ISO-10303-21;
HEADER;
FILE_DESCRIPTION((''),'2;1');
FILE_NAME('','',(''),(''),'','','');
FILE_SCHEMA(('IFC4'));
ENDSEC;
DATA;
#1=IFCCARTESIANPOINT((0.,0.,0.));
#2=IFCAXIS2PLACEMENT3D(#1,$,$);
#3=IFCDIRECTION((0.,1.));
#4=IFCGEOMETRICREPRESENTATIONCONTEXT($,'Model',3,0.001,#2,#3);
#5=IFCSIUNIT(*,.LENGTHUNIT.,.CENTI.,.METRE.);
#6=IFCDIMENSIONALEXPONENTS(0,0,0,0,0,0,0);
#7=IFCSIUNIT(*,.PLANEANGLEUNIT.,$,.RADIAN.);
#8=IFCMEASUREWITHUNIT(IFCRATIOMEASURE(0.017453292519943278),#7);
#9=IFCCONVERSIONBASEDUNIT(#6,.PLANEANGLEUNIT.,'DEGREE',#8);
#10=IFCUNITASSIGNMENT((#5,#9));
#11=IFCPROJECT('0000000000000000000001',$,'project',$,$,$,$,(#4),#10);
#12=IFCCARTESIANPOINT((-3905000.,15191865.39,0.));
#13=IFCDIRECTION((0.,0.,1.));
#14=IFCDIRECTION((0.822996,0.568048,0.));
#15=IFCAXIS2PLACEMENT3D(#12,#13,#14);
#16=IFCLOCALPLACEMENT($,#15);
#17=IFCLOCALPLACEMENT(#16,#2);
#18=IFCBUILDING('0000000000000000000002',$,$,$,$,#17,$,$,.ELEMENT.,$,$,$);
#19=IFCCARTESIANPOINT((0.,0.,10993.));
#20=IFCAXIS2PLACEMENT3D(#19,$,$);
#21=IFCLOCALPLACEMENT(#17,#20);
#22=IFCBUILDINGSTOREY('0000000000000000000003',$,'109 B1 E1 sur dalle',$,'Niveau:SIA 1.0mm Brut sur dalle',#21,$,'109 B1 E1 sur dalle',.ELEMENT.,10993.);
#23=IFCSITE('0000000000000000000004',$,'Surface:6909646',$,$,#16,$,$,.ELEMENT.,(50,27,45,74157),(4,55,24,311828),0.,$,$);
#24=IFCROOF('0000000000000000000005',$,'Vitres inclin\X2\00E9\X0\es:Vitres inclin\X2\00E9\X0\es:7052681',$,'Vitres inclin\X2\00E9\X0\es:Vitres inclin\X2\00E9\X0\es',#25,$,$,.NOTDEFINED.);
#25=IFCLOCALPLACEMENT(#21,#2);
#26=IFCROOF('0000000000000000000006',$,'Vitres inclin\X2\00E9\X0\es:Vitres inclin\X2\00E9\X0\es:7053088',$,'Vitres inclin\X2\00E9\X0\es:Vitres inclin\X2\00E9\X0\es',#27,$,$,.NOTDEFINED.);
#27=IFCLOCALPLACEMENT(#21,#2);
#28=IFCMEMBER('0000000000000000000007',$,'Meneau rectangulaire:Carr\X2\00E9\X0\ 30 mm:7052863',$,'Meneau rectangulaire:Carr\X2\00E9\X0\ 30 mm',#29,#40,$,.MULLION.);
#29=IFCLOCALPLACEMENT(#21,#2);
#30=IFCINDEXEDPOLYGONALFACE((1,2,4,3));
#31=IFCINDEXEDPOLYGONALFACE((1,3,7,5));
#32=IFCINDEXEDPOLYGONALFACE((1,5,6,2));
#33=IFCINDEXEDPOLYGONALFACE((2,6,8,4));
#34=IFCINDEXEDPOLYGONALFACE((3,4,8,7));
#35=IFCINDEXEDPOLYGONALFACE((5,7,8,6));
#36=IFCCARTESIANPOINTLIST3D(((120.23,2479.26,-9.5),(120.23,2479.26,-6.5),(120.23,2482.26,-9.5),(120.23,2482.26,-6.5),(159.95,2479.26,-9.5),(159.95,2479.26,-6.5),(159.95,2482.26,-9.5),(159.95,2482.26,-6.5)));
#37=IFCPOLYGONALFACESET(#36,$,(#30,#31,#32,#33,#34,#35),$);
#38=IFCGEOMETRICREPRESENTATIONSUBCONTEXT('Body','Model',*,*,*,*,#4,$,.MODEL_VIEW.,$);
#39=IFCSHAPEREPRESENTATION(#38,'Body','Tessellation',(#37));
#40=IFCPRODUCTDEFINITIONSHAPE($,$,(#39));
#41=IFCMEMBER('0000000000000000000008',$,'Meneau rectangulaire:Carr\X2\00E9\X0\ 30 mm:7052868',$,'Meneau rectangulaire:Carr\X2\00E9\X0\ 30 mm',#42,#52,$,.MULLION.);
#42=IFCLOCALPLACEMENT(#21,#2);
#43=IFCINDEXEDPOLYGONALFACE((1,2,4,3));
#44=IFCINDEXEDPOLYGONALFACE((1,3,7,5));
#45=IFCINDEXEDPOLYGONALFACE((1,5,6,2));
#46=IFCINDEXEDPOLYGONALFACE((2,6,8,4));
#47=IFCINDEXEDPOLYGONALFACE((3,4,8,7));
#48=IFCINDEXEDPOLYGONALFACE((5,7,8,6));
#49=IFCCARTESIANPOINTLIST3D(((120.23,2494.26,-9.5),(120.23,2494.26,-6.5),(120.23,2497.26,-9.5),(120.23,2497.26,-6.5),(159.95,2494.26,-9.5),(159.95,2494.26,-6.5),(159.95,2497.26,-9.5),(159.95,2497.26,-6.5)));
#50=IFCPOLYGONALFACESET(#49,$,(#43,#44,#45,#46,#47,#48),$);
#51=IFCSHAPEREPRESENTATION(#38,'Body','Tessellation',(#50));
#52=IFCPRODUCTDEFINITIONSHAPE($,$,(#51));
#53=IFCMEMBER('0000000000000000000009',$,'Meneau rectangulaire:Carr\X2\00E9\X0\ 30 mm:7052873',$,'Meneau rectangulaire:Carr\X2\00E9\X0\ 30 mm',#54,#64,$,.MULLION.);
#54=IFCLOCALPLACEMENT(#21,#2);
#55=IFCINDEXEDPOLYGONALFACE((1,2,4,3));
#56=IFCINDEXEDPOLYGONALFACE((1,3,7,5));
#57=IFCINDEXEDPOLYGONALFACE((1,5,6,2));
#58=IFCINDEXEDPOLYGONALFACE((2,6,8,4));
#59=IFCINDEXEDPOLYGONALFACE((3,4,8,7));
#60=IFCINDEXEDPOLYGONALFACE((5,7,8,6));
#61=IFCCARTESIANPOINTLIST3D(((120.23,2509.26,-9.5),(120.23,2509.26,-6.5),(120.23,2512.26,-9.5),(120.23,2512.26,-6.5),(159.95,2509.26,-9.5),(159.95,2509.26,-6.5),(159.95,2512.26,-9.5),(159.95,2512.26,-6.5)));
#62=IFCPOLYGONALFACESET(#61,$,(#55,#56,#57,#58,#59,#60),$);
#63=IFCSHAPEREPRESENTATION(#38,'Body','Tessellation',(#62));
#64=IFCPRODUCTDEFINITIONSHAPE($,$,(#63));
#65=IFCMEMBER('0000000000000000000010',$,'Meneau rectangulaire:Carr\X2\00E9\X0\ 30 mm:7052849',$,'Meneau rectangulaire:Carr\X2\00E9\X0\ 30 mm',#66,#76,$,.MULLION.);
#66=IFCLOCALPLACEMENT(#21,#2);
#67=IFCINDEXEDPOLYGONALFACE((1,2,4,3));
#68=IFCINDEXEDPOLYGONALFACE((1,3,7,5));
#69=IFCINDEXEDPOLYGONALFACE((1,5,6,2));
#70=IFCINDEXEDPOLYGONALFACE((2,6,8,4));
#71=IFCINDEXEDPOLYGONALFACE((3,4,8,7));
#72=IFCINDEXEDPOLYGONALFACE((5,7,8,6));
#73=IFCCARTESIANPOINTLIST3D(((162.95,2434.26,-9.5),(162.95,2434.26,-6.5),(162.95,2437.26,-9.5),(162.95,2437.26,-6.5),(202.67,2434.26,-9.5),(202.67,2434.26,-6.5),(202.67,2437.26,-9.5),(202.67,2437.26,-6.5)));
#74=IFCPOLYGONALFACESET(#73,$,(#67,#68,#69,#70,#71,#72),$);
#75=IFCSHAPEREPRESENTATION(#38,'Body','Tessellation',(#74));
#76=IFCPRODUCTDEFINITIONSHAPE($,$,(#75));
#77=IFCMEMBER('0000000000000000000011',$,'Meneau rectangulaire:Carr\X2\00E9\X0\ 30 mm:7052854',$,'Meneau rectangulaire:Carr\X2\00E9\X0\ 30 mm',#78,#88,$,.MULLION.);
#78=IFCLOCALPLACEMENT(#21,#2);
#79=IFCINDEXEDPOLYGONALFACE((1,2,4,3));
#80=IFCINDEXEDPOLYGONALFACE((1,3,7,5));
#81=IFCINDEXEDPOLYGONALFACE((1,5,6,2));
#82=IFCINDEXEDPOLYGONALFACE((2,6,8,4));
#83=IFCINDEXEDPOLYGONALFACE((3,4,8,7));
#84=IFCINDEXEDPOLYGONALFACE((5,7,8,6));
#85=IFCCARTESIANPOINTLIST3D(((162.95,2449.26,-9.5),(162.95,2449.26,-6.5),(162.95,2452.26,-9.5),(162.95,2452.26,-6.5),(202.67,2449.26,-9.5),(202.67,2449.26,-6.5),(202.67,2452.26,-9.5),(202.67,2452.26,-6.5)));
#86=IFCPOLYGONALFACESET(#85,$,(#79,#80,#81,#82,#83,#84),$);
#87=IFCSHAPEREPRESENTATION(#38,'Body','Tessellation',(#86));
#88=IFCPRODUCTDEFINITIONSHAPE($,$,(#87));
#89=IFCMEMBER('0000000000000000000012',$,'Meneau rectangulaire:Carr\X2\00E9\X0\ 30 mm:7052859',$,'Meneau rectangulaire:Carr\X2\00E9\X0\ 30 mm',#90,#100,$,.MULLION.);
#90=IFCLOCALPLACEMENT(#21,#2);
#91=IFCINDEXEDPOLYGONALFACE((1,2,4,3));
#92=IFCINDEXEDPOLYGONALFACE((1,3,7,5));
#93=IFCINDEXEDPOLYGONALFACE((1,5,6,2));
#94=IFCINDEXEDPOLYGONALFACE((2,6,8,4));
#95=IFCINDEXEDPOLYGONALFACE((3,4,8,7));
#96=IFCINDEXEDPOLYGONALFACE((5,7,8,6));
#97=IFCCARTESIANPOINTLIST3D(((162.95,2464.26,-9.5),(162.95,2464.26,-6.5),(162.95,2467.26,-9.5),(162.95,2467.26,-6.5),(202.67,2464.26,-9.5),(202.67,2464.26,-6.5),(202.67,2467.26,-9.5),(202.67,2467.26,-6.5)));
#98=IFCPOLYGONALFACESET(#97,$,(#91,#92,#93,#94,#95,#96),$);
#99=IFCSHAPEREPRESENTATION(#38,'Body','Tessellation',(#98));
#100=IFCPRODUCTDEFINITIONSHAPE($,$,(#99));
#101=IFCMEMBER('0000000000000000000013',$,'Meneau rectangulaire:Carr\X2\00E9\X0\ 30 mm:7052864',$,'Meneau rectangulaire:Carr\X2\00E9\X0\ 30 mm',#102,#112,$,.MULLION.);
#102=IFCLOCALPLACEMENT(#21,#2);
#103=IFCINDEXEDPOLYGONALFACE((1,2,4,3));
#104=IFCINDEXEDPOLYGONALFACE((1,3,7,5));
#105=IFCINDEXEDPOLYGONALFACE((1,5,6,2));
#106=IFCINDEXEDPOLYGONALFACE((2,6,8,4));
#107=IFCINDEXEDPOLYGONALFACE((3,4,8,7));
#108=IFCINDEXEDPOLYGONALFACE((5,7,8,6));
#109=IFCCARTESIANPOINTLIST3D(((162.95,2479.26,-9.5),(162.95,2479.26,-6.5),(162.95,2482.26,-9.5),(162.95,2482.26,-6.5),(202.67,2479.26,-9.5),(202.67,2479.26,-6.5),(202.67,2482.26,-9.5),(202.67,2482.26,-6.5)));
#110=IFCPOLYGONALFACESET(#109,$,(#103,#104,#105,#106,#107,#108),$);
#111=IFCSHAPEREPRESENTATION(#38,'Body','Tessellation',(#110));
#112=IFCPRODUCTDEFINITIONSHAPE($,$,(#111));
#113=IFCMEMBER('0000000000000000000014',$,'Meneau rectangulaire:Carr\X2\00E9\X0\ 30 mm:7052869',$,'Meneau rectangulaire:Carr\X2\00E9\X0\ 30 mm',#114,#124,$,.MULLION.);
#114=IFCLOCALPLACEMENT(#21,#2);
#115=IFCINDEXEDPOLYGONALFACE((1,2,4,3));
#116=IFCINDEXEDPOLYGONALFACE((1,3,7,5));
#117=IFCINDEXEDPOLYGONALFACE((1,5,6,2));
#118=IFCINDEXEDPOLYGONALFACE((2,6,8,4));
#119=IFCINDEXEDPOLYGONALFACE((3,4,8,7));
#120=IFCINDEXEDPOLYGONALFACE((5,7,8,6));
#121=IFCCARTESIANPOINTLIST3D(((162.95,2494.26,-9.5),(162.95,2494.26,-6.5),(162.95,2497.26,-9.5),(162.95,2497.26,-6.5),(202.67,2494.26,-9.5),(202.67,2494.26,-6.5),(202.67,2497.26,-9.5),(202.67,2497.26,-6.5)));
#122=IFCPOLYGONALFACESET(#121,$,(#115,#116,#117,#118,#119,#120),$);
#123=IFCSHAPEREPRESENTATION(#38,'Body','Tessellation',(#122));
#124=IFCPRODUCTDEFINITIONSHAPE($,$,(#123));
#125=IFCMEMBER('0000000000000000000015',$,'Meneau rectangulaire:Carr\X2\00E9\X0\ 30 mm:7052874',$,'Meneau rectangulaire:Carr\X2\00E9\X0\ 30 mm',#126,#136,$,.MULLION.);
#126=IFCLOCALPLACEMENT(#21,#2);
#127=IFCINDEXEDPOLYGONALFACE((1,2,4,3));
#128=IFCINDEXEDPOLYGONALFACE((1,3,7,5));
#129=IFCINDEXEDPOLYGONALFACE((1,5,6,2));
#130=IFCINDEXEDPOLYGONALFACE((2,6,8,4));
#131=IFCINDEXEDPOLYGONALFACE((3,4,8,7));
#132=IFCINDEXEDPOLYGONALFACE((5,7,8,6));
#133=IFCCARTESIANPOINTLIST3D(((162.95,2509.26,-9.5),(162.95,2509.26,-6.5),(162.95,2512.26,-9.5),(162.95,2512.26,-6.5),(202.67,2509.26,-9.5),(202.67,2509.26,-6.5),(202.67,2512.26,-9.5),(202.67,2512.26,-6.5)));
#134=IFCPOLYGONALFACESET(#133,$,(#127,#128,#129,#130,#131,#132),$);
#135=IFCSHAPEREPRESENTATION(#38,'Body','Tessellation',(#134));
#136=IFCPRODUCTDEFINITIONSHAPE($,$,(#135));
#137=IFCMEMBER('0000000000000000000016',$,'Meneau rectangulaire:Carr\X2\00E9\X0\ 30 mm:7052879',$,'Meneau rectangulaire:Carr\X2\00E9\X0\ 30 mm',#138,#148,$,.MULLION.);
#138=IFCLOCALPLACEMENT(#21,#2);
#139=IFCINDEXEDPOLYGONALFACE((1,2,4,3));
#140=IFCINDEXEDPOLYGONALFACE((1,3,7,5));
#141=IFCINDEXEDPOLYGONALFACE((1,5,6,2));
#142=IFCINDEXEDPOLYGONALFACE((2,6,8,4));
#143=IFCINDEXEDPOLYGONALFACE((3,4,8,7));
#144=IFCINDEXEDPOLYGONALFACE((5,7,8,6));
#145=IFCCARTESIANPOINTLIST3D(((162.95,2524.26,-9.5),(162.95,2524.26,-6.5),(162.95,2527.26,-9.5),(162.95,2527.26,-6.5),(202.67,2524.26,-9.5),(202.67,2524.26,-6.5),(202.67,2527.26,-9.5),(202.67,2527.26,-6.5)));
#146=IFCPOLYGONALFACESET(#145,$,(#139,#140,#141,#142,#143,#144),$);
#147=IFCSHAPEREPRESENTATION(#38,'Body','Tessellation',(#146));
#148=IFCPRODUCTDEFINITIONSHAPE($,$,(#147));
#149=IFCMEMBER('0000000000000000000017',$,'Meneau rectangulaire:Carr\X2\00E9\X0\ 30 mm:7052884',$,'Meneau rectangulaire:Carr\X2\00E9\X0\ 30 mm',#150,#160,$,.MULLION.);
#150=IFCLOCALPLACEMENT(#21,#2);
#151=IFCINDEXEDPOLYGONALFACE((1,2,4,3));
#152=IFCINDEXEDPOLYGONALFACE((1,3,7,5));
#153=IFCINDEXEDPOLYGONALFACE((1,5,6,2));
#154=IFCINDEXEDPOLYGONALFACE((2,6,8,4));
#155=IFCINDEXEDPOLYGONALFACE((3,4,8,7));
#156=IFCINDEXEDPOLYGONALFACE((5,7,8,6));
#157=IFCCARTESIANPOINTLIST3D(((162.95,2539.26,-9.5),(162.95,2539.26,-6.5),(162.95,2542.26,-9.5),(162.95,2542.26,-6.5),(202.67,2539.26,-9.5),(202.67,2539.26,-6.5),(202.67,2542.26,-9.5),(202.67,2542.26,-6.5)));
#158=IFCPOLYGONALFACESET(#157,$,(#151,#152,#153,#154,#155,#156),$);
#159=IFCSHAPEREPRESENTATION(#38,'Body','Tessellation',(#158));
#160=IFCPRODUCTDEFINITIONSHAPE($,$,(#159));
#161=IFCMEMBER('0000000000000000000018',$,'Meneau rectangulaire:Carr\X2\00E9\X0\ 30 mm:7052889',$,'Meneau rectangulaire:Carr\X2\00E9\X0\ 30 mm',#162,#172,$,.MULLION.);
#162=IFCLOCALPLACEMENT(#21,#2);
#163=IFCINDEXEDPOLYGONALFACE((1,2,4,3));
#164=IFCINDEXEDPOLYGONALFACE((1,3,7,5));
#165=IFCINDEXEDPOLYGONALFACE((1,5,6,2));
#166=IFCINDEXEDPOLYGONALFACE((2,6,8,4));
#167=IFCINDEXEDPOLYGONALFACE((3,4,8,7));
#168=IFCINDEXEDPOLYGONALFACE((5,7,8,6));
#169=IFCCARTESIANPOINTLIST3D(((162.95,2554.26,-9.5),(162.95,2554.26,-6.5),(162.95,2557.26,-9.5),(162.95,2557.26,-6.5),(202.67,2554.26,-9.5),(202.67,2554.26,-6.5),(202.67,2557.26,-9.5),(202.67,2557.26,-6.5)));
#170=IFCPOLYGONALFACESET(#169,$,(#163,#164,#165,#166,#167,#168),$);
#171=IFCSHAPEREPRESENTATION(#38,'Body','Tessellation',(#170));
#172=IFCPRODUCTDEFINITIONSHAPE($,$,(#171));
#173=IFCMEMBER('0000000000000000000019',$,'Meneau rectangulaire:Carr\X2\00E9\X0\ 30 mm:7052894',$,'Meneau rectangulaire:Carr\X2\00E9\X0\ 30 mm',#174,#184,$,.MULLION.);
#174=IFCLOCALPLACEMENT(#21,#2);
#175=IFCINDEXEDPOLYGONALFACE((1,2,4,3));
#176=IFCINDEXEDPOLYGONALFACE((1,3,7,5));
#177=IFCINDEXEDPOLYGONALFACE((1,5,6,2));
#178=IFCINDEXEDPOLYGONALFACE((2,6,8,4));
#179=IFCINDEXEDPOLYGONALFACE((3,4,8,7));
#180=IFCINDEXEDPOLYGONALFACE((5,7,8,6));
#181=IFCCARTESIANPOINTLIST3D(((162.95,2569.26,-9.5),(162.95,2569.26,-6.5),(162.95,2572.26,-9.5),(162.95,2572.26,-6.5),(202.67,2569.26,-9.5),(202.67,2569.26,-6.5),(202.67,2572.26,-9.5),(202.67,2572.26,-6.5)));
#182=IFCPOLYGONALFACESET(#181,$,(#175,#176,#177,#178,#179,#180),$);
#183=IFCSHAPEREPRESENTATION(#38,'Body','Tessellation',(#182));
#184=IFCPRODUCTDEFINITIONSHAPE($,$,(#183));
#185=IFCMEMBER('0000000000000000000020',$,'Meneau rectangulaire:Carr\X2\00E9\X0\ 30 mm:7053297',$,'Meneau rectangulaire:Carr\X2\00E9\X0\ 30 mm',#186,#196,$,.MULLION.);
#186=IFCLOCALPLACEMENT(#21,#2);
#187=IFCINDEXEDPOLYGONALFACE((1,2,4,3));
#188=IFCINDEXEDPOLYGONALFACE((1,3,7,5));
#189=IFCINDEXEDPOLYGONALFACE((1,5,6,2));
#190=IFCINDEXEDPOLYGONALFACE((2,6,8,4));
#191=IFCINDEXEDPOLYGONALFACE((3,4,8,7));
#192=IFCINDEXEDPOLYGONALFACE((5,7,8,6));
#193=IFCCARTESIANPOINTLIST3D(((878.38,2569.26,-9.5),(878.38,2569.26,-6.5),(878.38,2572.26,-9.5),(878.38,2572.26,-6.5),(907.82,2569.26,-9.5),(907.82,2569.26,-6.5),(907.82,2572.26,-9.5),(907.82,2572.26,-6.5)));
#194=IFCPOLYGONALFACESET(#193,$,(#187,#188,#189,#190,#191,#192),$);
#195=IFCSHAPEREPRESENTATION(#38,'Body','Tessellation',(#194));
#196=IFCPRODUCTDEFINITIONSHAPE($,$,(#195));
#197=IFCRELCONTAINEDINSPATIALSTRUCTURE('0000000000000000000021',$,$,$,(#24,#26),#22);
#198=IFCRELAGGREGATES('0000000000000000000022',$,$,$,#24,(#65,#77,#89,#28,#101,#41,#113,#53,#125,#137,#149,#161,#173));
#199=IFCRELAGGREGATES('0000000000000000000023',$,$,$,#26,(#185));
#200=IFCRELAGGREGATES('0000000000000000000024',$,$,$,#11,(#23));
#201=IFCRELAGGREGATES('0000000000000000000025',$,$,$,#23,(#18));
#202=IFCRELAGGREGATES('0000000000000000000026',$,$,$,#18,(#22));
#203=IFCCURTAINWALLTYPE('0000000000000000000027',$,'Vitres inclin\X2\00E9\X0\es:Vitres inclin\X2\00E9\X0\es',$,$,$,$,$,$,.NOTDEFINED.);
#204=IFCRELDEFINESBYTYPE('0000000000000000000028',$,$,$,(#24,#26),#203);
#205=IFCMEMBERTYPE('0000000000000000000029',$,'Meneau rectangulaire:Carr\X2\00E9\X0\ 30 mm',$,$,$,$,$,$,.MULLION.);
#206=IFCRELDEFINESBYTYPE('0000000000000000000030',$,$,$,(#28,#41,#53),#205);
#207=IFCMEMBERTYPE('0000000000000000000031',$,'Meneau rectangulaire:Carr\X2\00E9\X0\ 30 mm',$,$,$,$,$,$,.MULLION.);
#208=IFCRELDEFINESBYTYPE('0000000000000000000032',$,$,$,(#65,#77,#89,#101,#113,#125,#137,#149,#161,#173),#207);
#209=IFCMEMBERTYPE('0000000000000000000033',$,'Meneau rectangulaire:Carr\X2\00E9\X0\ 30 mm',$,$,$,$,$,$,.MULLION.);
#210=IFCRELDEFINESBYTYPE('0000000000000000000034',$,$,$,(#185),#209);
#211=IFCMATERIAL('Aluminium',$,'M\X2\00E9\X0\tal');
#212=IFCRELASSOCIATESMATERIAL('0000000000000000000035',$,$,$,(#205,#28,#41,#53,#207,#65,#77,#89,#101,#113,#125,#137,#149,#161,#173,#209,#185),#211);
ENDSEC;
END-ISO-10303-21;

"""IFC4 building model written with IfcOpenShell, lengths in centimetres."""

from ifc_helpers import new_model, entity, si_unit, converted_unit, direction, frame, origin, place, context, subcontext, project, spatial, indexed_curve, outline, extrude, source, transform, mapped, material, type_object, type_shapes, element, aggregate, save


model = new_model("IFC4")

# Units and contexts
model_context = context("Model", 3, precision=0.001, world=origin(), true_north=direction((0.0, 1.0)))
body_context = subcontext(model_context, "Body", "Model", "MODEL_VIEW")
ifc_project = project(units=[si_unit("LENGTHUNIT", "METRE", prefix="CENTI"), converted_unit("PLANEANGLEUNIT", "DEGREE", entity("IfcRatioMeasure", 0.017453292519943278), si_unit("PLANEANGLEUNIT", "RADIAN"), dimensions=[0, 0, 0, 0, 0, 0, 0])], contexts=[model_context])

# Site, building, storey
site_placement = place(None, frame((-3905000.0, 15191865.39, 0.0), z_axis=(0.0, 0.0, 1.0), x_axis=(0.822996, 0.568048, 0.0)))
site = spatial("IfcSite", under=ifc_project, at=site_placement, Name="Surface:6909646", CompositionType="ELEMENT", RefLatitude=(50, 27, 45, 74157), RefLongitude=(4, 55, 24, 311828), RefElevation=0.0)
building_placement = place(site_placement, origin())
building = spatial("IfcBuilding", under=site, at=building_placement, CompositionType="ELEMENT")
storey_placement = place(building_placement, frame((0.0, 0.0, 10993.0)))
storey = spatial("IfcBuildingStorey", under=building, at=storey_placement, Name="109 B1 E1 sur dalle", ObjectType="Niveau:SIA 1.0mm Brut sur dalle", LongName="109 B1 E1 sur dalle", CompositionType="ELEMENT", Elevation=10993.0)

# Roofs
curtain_wall_type = type_object("IfcCurtainWallType", Name="Vitres inclinées:Vitres inclinées", PredefinedType="NOTDEFINED")
roof_1_placement = place(storey_placement, frame((0.0, 0.0, -10993.0)))
roof_1 = element("IfcRoof", 1, at=roof_1_placement, inside=storey, type_object=curtain_wall_type, Name="Vitres inclinées:Vitres inclinées:7052681", ObjectType="Vitres inclinées:Vitres inclinées", PredefinedType="NOTDEFINED")
ifc_material = material(Name="Aluminium", Category="Métal")
roof_2_placement = place(storey_placement, frame((0.0, 0.0, -10993.0)))
roof_2 = element("IfcRoof", 2, at=roof_2_placement, inside=storey, type_object=curtain_wall_type, Name="Vitres inclinées:Vitres inclinées:7053088", ObjectType="Vitres inclinées:Vitres inclinées", PredefinedType="NOTDEFINED")

# Members
member_type_1 = type_object("IfcMemberType", Name="Meneau rectangulaire:Carré 30 mm", PredefinedType="MULLION", material=ifc_material)
shared_shape_1 = source(origin(), body_context, "Body", "SweptSolid", [
    extrude(outline(indexed_curve([(-1.5, -1.5), (1.5, -1.5), (1.5, 1.5), (-1.5, 1.5), (-1.5, -1.5)], self_intersect=False)), frame((0.0, 0.0, -39.72), z_axis=(0.0, 0.0, 1.0), x_axis=(0.0, -1.0, 0.0)), (0.0, 0.0, 1.0), 39.72),
])
type_shapes(member_type_1, [shared_shape_1])
member_1_placement = place(roof_1_placement, frame((120.23, 2480.76, 10985.0), z_axis=(-1.0, 0.0, 0.0), x_axis=(0.0, 1.0, 0.0)))
member_1 = element("IfcMember", 3, at=member_1_placement, type_object=member_type_1, material=ifc_material, Name="Meneau rectangulaire:Carré 30 mm:7052863", ObjectType="Meneau rectangulaire:Carré 30 mm", PredefinedType="MULLION", context=body_context, shape_type="MappedRepresentation", body=[
    mapped(shared_shape_1, transform((0.0, 0.0, 0.0), scale=1.0)),
])
member_2_placement = place(roof_1_placement, frame((120.23, 2495.76, 10985.0), z_axis=(-1.0, 0.0, 0.0), x_axis=(0.0, 1.0, 0.0)))
member_2 = element("IfcMember", 4, at=member_2_placement, type_object=member_type_1, material=ifc_material, Name="Meneau rectangulaire:Carré 30 mm:7052868", ObjectType="Meneau rectangulaire:Carré 30 mm", PredefinedType="MULLION", context=body_context, shape_type="MappedRepresentation", body=[
    mapped(shared_shape_1, transform((0.0, 0.0, 0.0), scale=1.0)),
])
member_3_placement = place(roof_1_placement, frame((120.23, 2510.76, 10985.0), z_axis=(-1.0, 0.0, 0.0), x_axis=(0.0, 1.0, 0.0)))
member_3 = element("IfcMember", 5, at=member_3_placement, type_object=member_type_1, material=ifc_material, Name="Meneau rectangulaire:Carré 30 mm:7052873", ObjectType="Meneau rectangulaire:Carré 30 mm", PredefinedType="MULLION", context=body_context, shape_type="MappedRepresentation", body=[
    mapped(shared_shape_1, transform((0.0, 0.0, 0.0), scale=1.0)),
])
member_type_2 = type_object("IfcMemberType", Name="Meneau rectangulaire:Carré 30 mm", PredefinedType="MULLION", material=ifc_material)
shared_shape_2 = source(origin(), body_context, "Body", "SweptSolid", [
    extrude(outline(indexed_curve([(-1.5, -1.5), (1.5, -1.5), (1.5, 1.5), (-1.5, 1.5), (-1.5, -1.5)], self_intersect=False)), frame((0.0, 0.0, -39.72), z_axis=(0.0, 0.0, 1.0), x_axis=(0.0, -1.0, 0.0)), (0.0, 0.0, 1.0), 39.72),
])
type_shapes(member_type_2, [shared_shape_2])
member_4_placement = place(roof_1_placement, frame((162.95, 2435.76, 10985.0), z_axis=(-1.0, 0.0, 0.0), x_axis=(0.0, 1.0, 0.0)))
member_4 = element("IfcMember", 6, at=member_4_placement, type_object=member_type_2, material=ifc_material, Name="Meneau rectangulaire:Carré 30 mm:7052849", ObjectType="Meneau rectangulaire:Carré 30 mm", PredefinedType="MULLION", context=body_context, shape_type="MappedRepresentation", body=[
    mapped(shared_shape_2, transform((0.0, 0.0, 0.0), scale=1.0)),
])
member_5_placement = place(roof_1_placement, frame((162.95, 2450.76, 10985.0), z_axis=(-1.0, 0.0, 0.0), x_axis=(0.0, 1.0, 0.0)))
member_5 = element("IfcMember", 7, at=member_5_placement, type_object=member_type_2, material=ifc_material, Name="Meneau rectangulaire:Carré 30 mm:7052854", ObjectType="Meneau rectangulaire:Carré 30 mm", PredefinedType="MULLION", context=body_context, shape_type="MappedRepresentation", body=[
    mapped(shared_shape_2, transform((0.0, 0.0, 0.0), scale=1.0)),
])
member_6_placement = place(roof_1_placement, frame((162.95, 2465.76, 10985.0), z_axis=(-1.0, 0.0, 0.0), x_axis=(0.0, 1.0, 0.0)))
member_6 = element("IfcMember", 8, at=member_6_placement, type_object=member_type_2, material=ifc_material, Name="Meneau rectangulaire:Carré 30 mm:7052859", ObjectType="Meneau rectangulaire:Carré 30 mm", PredefinedType="MULLION", context=body_context, shape_type="MappedRepresentation", body=[
    mapped(shared_shape_2, transform((0.0, 0.0, 0.0), scale=1.0)),
])
member_7_placement = place(roof_1_placement, frame((162.95, 2480.76, 10985.0), z_axis=(-1.0, 0.0, 0.0), x_axis=(0.0, 1.0, 0.0)))
member_7 = element("IfcMember", 9, at=member_7_placement, type_object=member_type_2, material=ifc_material, Name="Meneau rectangulaire:Carré 30 mm:7052864", ObjectType="Meneau rectangulaire:Carré 30 mm", PredefinedType="MULLION", context=body_context, shape_type="MappedRepresentation", body=[
    mapped(shared_shape_2, transform((0.0, 0.0, 0.0), scale=1.0)),
])
member_8_placement = place(roof_1_placement, frame((162.95, 2495.76, 10985.0), z_axis=(-1.0, 0.0, 0.0), x_axis=(0.0, 1.0, 0.0)))
member_8 = element("IfcMember", 10, at=member_8_placement, type_object=member_type_2, material=ifc_material, Name="Meneau rectangulaire:Carré 30 mm:7052869", ObjectType="Meneau rectangulaire:Carré 30 mm", PredefinedType="MULLION", context=body_context, shape_type="MappedRepresentation", body=[
    mapped(shared_shape_2, transform((0.0, 0.0, 0.0), scale=1.0)),
])
member_9_placement = place(roof_1_placement, frame((162.95, 2510.76, 10985.0), z_axis=(-1.0, 0.0, 0.0), x_axis=(0.0, 1.0, 0.0)))
member_9 = element("IfcMember", 11, at=member_9_placement, type_object=member_type_2, material=ifc_material, Name="Meneau rectangulaire:Carré 30 mm:7052874", ObjectType="Meneau rectangulaire:Carré 30 mm", PredefinedType="MULLION", context=body_context, shape_type="MappedRepresentation", body=[
    mapped(shared_shape_2, transform((0.0, 0.0, 0.0), scale=1.0)),
])
member_10_placement = place(roof_1_placement, frame((162.95, 2525.76, 10985.0), z_axis=(-1.0, 0.0, 0.0), x_axis=(0.0, 1.0, 0.0)))
member_10 = element("IfcMember", 12, at=member_10_placement, type_object=member_type_2, material=ifc_material, Name="Meneau rectangulaire:Carré 30 mm:7052879", ObjectType="Meneau rectangulaire:Carré 30 mm", PredefinedType="MULLION", context=body_context, shape_type="MappedRepresentation", body=[
    mapped(shared_shape_2, transform((0.0, 0.0, 0.0), scale=1.0)),
])
member_11_placement = place(roof_1_placement, frame((162.95, 2540.76, 10985.0), z_axis=(-1.0, 0.0, 0.0), x_axis=(0.0, 1.0, 0.0)))
member_11 = element("IfcMember", 13, at=member_11_placement, type_object=member_type_2, material=ifc_material, Name="Meneau rectangulaire:Carré 30 mm:7052884", ObjectType="Meneau rectangulaire:Carré 30 mm", PredefinedType="MULLION", context=body_context, shape_type="MappedRepresentation", body=[
    mapped(shared_shape_2, transform((0.0, 0.0, 0.0), scale=1.0)),
])
member_12_placement = place(roof_1_placement, frame((162.95, 2555.76, 10985.0), z_axis=(-1.0, 0.0, 0.0), x_axis=(0.0, 1.0, 0.0)))
member_12 = element("IfcMember", 14, at=member_12_placement, type_object=member_type_2, material=ifc_material, Name="Meneau rectangulaire:Carré 30 mm:7052889", ObjectType="Meneau rectangulaire:Carré 30 mm", PredefinedType="MULLION", context=body_context, shape_type="MappedRepresentation", body=[
    mapped(shared_shape_2, transform((0.0, 0.0, 0.0), scale=1.0)),
])
member_13_placement = place(roof_1_placement, frame((162.95, 2570.76, 10985.0), z_axis=(-1.0, 0.0, 0.0), x_axis=(0.0, 1.0, 0.0)))
member_13 = element("IfcMember", 15, at=member_13_placement, type_object=member_type_2, material=ifc_material, Name="Meneau rectangulaire:Carré 30 mm:7052894", ObjectType="Meneau rectangulaire:Carré 30 mm", PredefinedType="MULLION", context=body_context, shape_type="MappedRepresentation", body=[
    mapped(shared_shape_2, transform((0.0, 0.0, 0.0), scale=1.0)),
])
aggregate(roof_1, [member_4, member_5, member_6, member_1, member_7, member_2, member_8, member_3, member_9, member_10, member_11, member_12, member_13])
member_type_3 = type_object("IfcMemberType", Name="Meneau rectangulaire:Carré 30 mm", PredefinedType="MULLION", material=ifc_material)
shared_shape_3 = source(origin(), body_context, "Body", "SweptSolid", [
    extrude(outline(indexed_curve([(-1.5, -1.5), (1.5, -1.5), (1.5, 1.5), (-1.5, 1.5), (-1.5, -1.5)], self_intersect=False)), frame((0.0, 0.0, -29.44), z_axis=(0.0, 0.0, 1.0), x_axis=(0.0, -1.0, 0.0)), (0.0, 0.0, 1.0), 29.44),
])
type_shapes(member_type_3, [shared_shape_3])
member_14_placement = place(roof_2_placement, frame((878.38, 2570.76, 10985.0), z_axis=(-1.0, 0.0, 0.0), x_axis=(0.0, 1.0, 0.0)))
member_14 = element("IfcMember", 16, at=member_14_placement, type_object=member_type_3, material=ifc_material, Name="Meneau rectangulaire:Carré 30 mm:7053297", ObjectType="Meneau rectangulaire:Carré 30 mm", PredefinedType="MULLION", context=body_context, shape_type="MappedRepresentation", body=[
    mapped(shared_shape_3, transform((0.0, 0.0, 0.0), scale=1.0)),
])
aggregate(roof_2, [member_14])

save(model, "model.ifc")
